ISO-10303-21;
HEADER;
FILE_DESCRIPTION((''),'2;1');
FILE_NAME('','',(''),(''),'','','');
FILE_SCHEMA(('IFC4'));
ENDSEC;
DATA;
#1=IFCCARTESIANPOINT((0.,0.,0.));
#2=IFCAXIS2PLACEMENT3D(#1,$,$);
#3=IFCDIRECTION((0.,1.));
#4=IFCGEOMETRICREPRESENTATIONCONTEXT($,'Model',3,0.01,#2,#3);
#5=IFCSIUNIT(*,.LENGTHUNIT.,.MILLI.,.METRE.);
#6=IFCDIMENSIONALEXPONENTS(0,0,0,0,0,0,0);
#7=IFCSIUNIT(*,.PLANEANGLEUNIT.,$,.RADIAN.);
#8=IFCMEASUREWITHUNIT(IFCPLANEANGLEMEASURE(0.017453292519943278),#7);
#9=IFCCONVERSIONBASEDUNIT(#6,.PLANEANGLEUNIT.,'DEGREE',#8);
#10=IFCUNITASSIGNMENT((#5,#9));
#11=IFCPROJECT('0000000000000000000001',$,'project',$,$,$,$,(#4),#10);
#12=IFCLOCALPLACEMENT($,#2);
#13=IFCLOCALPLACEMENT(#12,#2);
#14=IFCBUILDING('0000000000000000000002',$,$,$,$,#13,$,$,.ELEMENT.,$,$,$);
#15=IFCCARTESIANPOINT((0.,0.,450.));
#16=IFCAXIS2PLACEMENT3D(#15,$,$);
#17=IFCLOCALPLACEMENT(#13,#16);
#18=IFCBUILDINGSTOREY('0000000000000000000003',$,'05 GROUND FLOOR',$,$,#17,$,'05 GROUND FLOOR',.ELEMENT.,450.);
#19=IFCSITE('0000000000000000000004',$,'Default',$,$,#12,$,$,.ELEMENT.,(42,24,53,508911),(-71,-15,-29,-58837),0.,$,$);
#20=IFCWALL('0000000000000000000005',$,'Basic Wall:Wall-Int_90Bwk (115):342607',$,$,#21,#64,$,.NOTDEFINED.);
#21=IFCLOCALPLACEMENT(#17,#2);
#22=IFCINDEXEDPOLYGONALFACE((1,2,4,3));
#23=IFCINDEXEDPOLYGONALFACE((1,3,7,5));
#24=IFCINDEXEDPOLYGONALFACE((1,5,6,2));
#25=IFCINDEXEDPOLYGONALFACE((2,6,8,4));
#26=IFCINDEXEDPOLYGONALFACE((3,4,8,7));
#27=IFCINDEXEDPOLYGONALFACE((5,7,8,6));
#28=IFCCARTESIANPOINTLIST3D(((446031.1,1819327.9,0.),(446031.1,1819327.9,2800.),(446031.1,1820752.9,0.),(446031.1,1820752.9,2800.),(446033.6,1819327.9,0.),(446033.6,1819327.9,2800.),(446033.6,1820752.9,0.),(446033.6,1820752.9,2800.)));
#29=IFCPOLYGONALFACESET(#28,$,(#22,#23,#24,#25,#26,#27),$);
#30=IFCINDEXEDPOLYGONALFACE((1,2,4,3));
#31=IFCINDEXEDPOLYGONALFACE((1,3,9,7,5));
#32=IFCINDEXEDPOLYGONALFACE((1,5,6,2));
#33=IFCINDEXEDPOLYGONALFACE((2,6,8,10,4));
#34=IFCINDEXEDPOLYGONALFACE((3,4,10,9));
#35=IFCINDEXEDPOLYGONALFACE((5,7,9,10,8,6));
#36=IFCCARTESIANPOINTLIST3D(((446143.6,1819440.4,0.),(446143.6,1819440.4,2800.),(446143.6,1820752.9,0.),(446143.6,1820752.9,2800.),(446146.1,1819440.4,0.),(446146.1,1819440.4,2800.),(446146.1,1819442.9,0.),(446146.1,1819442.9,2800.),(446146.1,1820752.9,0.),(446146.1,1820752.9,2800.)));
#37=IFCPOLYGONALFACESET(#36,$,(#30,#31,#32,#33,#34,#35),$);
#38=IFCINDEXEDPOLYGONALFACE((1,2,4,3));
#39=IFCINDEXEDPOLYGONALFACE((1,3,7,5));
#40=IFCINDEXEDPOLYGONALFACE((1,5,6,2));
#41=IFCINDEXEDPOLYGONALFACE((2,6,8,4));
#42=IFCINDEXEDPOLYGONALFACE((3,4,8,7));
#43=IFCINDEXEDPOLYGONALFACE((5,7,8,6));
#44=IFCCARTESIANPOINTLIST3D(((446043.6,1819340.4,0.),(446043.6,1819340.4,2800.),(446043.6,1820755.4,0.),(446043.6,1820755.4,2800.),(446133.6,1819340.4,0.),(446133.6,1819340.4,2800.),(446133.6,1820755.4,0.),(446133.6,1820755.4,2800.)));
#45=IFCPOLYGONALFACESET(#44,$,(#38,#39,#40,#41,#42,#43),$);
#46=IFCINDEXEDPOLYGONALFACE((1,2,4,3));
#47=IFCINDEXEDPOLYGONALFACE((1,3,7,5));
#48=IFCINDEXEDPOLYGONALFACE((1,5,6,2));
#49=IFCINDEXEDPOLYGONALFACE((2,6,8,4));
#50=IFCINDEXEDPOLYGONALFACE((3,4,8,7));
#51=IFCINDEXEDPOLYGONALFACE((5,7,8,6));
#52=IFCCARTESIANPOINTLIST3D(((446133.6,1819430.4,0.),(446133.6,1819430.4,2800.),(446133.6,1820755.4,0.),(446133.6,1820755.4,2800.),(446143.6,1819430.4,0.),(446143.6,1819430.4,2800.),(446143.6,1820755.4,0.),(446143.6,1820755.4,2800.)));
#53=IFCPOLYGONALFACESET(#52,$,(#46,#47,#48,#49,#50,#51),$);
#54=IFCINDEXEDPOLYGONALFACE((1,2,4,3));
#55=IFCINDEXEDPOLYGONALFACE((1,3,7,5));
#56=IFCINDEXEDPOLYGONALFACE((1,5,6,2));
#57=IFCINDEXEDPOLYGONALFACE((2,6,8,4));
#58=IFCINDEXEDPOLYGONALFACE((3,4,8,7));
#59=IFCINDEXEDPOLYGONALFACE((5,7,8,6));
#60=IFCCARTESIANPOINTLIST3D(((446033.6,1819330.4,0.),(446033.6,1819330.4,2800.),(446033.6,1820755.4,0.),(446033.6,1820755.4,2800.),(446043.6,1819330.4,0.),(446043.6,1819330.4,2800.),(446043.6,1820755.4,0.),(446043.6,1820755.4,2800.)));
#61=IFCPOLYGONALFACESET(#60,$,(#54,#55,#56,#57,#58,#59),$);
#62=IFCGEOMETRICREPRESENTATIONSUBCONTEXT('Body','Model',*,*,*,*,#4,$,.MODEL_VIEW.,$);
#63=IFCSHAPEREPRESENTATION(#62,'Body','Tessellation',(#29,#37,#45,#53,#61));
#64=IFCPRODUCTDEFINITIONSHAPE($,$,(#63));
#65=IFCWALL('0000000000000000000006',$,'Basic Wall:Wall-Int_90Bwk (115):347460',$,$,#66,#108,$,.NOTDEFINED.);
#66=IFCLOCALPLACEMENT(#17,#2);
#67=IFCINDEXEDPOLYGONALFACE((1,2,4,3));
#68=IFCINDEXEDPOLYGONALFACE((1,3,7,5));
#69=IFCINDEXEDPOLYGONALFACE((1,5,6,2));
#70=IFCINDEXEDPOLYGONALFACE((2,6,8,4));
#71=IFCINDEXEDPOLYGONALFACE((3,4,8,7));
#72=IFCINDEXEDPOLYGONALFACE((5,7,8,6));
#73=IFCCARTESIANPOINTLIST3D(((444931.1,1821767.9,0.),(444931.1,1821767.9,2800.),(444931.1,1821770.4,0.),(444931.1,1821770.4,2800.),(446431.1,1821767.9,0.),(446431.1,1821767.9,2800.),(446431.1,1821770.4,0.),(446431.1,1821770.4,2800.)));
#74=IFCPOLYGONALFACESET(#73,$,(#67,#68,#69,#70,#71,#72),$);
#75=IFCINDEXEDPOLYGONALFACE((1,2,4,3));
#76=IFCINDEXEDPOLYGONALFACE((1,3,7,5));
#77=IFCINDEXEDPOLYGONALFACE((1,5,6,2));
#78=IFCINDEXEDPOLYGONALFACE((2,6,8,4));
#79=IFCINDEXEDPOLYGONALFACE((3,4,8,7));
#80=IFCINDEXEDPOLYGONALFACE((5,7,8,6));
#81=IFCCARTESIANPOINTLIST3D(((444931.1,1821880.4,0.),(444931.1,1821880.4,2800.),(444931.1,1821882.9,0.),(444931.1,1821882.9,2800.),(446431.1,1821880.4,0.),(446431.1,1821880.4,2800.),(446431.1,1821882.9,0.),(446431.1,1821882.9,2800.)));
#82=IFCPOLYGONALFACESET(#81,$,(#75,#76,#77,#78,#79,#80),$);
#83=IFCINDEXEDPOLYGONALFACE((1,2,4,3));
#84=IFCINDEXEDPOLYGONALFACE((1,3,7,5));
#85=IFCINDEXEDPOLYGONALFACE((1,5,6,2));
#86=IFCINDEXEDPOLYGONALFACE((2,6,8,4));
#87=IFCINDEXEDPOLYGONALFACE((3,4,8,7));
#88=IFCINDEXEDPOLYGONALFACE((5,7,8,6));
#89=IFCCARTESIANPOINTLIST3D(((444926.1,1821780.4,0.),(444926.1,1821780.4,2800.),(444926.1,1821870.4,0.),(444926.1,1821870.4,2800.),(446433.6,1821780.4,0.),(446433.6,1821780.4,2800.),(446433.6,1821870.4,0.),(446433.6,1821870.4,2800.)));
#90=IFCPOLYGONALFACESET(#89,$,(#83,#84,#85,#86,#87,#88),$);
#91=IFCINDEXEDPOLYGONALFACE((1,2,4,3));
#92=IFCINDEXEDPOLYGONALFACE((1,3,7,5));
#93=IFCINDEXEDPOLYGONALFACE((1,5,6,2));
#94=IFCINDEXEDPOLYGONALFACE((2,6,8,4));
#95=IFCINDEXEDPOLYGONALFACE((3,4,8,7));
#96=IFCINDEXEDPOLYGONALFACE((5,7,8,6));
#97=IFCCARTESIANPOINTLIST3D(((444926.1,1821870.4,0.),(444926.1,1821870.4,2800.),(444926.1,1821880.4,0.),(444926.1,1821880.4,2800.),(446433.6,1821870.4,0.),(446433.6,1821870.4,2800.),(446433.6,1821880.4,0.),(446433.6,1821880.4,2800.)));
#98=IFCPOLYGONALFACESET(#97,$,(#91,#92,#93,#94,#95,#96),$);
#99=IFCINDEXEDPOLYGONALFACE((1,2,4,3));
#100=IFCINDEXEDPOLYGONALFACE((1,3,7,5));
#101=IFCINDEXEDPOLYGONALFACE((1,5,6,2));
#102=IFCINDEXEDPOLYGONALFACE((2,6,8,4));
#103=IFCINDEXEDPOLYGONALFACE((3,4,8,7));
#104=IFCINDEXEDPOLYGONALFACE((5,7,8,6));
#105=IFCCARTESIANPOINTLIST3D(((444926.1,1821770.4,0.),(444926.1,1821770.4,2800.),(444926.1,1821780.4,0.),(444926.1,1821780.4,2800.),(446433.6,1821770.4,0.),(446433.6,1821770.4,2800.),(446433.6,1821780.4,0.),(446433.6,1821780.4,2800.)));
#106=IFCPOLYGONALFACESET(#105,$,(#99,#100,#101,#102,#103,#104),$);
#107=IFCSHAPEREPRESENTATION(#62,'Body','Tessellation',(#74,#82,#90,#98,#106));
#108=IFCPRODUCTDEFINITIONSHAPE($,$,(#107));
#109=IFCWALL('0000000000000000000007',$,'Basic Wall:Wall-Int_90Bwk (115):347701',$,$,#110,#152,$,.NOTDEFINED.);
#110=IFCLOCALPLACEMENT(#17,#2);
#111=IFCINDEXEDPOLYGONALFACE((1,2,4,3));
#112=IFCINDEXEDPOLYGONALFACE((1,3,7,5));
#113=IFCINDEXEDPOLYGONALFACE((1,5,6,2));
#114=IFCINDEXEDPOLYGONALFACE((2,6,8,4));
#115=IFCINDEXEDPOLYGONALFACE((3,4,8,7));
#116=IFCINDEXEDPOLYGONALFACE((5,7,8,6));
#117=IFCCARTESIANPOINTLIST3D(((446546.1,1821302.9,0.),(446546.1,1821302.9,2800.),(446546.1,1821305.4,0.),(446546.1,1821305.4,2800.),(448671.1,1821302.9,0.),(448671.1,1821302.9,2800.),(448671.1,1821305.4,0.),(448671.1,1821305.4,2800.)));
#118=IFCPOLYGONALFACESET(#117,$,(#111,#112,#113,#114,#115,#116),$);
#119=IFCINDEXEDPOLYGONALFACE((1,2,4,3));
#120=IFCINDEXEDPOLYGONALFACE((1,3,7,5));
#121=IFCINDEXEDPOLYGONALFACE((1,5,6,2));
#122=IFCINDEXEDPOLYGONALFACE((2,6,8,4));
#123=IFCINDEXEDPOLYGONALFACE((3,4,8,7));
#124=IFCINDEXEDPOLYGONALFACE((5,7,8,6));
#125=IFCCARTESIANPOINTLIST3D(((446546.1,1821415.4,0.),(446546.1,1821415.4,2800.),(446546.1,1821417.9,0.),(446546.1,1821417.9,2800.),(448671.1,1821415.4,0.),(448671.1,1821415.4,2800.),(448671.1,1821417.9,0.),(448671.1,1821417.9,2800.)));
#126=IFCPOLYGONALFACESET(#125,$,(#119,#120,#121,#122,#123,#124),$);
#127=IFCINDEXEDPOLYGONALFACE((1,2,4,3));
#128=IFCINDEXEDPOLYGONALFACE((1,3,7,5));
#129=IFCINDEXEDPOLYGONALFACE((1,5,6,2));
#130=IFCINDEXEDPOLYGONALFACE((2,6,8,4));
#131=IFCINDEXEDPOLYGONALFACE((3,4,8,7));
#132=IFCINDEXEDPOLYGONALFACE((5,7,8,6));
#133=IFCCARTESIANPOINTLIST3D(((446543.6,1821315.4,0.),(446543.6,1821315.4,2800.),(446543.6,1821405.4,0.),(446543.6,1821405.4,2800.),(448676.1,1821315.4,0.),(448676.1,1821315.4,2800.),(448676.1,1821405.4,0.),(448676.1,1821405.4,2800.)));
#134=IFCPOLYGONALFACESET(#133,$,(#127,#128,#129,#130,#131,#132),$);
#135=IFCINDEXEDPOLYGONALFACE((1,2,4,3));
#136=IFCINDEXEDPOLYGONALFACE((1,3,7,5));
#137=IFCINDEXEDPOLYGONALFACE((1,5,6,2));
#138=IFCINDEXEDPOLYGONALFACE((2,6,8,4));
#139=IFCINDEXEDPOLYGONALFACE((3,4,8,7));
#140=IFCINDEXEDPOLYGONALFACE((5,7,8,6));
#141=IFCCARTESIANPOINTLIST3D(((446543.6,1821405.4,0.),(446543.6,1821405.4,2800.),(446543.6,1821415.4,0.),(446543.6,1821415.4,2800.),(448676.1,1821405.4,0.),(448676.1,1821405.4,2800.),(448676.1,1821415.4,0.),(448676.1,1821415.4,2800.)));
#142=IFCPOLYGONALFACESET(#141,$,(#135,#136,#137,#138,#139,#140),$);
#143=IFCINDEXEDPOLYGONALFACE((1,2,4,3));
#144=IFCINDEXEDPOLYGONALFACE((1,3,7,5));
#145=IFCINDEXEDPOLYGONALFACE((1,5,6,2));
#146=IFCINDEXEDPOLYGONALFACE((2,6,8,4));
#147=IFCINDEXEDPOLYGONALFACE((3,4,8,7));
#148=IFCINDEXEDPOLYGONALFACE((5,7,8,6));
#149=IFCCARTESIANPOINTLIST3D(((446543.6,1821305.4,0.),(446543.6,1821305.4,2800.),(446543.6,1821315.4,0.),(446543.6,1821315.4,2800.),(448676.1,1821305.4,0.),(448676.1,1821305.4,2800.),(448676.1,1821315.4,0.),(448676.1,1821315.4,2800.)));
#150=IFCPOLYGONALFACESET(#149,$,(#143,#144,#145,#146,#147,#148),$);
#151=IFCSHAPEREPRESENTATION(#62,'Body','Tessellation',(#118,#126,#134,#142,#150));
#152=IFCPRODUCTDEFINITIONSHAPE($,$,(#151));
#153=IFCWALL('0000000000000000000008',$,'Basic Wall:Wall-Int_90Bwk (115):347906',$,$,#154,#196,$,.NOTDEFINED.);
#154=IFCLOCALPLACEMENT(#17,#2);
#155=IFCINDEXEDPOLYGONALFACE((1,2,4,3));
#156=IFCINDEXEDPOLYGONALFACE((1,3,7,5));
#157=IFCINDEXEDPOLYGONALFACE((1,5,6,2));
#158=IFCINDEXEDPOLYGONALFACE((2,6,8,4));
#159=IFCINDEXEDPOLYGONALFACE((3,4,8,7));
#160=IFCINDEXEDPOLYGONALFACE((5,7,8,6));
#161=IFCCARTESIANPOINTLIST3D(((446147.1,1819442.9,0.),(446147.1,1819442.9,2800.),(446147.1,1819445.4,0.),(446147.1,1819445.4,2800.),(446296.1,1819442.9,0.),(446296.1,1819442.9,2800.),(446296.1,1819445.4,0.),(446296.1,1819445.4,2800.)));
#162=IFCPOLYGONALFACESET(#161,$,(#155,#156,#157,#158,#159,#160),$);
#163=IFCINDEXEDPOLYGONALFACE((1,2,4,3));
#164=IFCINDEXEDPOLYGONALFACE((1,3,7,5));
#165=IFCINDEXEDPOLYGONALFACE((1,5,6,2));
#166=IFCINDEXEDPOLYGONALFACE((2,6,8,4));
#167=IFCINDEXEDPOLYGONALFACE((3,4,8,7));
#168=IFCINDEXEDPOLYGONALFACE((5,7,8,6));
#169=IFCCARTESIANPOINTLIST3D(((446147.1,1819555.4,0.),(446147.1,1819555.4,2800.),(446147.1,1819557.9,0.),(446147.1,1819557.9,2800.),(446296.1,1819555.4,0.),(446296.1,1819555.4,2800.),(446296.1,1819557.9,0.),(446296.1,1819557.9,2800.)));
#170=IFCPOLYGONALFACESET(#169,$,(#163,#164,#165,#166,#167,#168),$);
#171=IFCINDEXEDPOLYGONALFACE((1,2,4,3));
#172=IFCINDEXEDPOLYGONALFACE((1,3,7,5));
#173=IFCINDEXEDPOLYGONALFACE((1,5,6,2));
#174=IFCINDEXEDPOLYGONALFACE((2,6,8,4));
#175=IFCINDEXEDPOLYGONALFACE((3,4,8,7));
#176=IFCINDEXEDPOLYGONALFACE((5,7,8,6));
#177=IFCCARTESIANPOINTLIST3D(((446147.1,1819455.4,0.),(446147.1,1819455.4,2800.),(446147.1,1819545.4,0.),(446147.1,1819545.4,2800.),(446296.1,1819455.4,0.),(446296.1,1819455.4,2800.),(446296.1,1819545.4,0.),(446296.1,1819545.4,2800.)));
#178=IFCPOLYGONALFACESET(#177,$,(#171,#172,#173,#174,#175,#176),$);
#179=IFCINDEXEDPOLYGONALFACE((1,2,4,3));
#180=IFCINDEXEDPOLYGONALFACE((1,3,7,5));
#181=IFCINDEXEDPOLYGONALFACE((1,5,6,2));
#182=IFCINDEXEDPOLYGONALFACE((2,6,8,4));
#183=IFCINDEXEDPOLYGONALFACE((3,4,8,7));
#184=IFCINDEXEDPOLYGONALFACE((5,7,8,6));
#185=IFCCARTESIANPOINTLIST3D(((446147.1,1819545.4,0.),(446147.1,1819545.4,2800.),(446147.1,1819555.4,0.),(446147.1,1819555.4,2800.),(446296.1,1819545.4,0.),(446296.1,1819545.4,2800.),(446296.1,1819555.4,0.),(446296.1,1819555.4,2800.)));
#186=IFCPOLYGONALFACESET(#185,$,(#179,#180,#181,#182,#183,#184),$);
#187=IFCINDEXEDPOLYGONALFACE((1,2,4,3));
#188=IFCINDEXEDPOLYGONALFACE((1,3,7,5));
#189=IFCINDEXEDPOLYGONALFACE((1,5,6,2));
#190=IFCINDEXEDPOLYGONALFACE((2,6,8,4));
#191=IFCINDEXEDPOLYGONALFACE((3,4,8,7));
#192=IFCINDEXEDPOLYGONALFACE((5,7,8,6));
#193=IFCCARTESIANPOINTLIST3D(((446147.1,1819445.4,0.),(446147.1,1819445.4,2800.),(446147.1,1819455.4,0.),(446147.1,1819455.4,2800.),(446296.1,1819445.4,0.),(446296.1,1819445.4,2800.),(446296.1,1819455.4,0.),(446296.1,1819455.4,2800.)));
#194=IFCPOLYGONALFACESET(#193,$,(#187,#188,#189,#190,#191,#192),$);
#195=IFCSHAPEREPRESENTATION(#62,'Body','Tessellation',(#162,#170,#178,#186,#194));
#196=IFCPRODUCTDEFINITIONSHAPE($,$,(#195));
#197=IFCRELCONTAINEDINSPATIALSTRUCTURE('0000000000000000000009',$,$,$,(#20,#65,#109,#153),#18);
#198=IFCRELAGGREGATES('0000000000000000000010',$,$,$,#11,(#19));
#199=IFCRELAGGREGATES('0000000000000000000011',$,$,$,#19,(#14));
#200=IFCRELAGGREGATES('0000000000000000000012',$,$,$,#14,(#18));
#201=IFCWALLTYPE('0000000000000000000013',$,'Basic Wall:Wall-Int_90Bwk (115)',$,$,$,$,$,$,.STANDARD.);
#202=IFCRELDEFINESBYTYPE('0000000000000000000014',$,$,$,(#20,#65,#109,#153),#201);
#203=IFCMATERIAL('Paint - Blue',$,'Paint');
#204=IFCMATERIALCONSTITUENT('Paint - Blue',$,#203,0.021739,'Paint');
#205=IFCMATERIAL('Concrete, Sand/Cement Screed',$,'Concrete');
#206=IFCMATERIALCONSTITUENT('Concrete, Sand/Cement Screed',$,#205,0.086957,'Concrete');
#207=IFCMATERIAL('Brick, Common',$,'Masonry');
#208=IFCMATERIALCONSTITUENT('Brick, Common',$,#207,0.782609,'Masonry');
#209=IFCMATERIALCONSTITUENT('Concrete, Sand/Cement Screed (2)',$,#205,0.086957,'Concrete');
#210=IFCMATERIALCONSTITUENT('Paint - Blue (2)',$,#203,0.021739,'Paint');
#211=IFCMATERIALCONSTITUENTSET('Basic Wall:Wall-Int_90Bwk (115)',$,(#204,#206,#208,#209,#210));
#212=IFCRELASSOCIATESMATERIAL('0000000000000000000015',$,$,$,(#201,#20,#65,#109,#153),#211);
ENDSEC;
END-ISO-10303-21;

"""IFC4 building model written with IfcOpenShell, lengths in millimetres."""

from ifc_helpers import new_model, entity, si_unit, converted_unit, direction, frame, origin, place, context, subcontext, project, spatial, indexed_curve, outline, extrude, material, constituent, constituent_set, type_object, element, save


model = new_model("IFC4")

# Units and contexts
model_context = context("Model", 3, precision=0.01, world=origin(), true_north=direction((0.0, 1.0)))
body_context = subcontext(model_context, "Body", "Model", "MODEL_VIEW")
ifc_project = project(units=[si_unit("LENGTHUNIT", "METRE", prefix="MILLI"), converted_unit("PLANEANGLEUNIT", "DEGREE", entity("IfcPlaneAngleMeasure", 0.017453292519943278), si_unit("PLANEANGLEUNIT", "RADIAN"), dimensions=[0, 0, 0, 0, 0, 0, 0])], contexts=[model_context])

# Site, building, storey
site_placement = place(None, origin())
site = spatial("IfcSite", under=ifc_project, at=site_placement, Name="Default", CompositionType="ELEMENT", RefLatitude=(42, 24, 53, 508911), RefLongitude=(-71, -15, -29, -58837), RefElevation=0.0)
building_placement = place(site_placement, origin())
building = spatial("IfcBuilding", under=site, at=building_placement, CompositionType="ELEMENT")
storey_placement = place(building_placement, frame((0.0, 0.0, 450.0)))
storey = spatial("IfcBuildingStorey", under=building, at=storey_placement, Name="05 GROUND FLOOR", LongName="05 GROUND FLOOR", CompositionType="ELEMENT", Elevation=450.0)

# Shared definitions
ifc_material_1 = material(Name="Paint - Blue", Category="Paint")
ifc_constituent_1 = constituent(ifc_material_1, Name="Paint - Blue", Category="Paint", fraction=0.021739)
ifc_material_2 = material(Name="Concrete, Sand/Cement Screed", Category="Concrete")
ifc_constituent_2 = constituent(ifc_material_2, Name="Concrete, Sand/Cement Screed", Category="Concrete", fraction=0.086957)
ifc_material_3 = material(Name="Brick, Common", Category="Masonry")
ifc_constituent_3 = constituent(ifc_material_3, Name="Brick, Common", Category="Masonry", fraction=0.782609)
ifc_constituent_4 = constituent(ifc_material_2, Name="Concrete, Sand/Cement Screed (2)", Category="Concrete", fraction=0.086957)
ifc_constituent_5 = constituent(ifc_material_1, Name="Paint - Blue (2)", Category="Paint", fraction=0.021739)
ifc_constituent_set_1 = constituent_set(constituents=[ifc_constituent_1, ifc_constituent_2, ifc_constituent_3, ifc_constituent_4, ifc_constituent_5], Name="Basic Wall:Wall-Int_90Bwk (115)")
wall_type_1 = type_object("IfcWallType", Name="Basic Wall:Wall-Int_90Bwk (115)", PredefinedType="STANDARD", material=ifc_constituent_set_1)

# Wall
wall_1_placement = place(storey_placement, frame((446088.6, 1820752.9, 0.0), z_axis=(0.0, 0.0, 1.0), x_axis=(0.0, -1.0, 0.0)))
element("IfcWall", 1, at=wall_1_placement, inside=storey, type_object=wall_type_1, material=ifc_constituent_set_1, Name="Basic Wall:Wall-Int_90Bwk (115):342607", PredefinedType="NOTDEFINED", context=body_context, shape_type="SweptSolid", body=[
    extrude(outline(indexed_curve([(-1.3, -712.5), (1.2, -712.5), (1.2, 712.5), (-1.3, 712.5), (-1.3, -712.5)], self_intersect=False)), frame((712.5, -56.2, 0.0), z_axis=(0.0, 0.0, 1.0), x_axis=(0.0, 1.0, 0.0)), (0.0, 0.0, 1.0), 2800.0),
    extrude(outline(indexed_curve([(-523.0, -1.0), (787.0, -1.0), (787.0, 1.5), (-525.5, 1.5), (-525.5, -1.0), (-523.0, -1.0)], self_intersect=False)), frame((787.0, 56.5, 0.0), z_axis=(0.0, 0.0, 1.0), x_axis=(-1.0, 0.0, 0.0)), (0.0, 0.0, 1.0), 2800.0),
    extrude(outline(indexed_curve([(-707.5, -45.0), (707.5, -45.0), (707.5, 45.0), (-707.5, 45.0), (-707.5, -45.0)], self_intersect=False)), frame((705.0, 0.0, 0.0)), (0.0, 0.0, 1.0), 2800.0),
    extrude(outline(indexed_curve([(-662.5, -5.0), (662.5, -5.0), (662.5, 5.0), (-662.5, 5.0), (-662.5, -5.0)], self_intersect=False)), frame((660.0, 50.0, 0.0)), (0.0, 0.0, 1.0), 2800.0),
    extrude(outline(indexed_curve([(-712.5, -5.0), (712.5, -5.0), (712.5, 5.0), (-712.5, 5.0), (-712.5, -5.0)], self_intersect=False)), frame((710.0, -50.0, 0.0)), (0.0, 0.0, 1.0), 2800.0),
])

# Walls
wall_2_placement = place(storey_placement, frame((444931.1, 1821825.4, 0.0)))
element("IfcWall", 2, at=wall_2_placement, inside=storey, type_object=wall_type_1, material=ifc_constituent_set_1, Name="Basic Wall:Wall-Int_90Bwk (115):347460", PredefinedType="NOTDEFINED", context=body_context, shape_type="SweptSolid", body=[
    extrude(outline(indexed_curve([(-1.3, -750.0), (1.2, -750.0), (1.2, 750.0), (-1.3, 750.0), (-1.3, -750.0)], self_intersect=False)), frame((750.0, -56.2, 0.0), z_axis=(0.0, 0.0, 1.0), x_axis=(0.0, 1.0, 0.0)), (0.0, 0.0, 1.0), 2800.0),
    extrude(outline(indexed_curve([(-1.3, -750.0), (1.3, -750.0), (1.3, 750.0), (-1.3, 750.0), (-1.3, -750.0)], self_intersect=False)), frame((750.0, 56.3, 0.0), z_axis=(0.0, 0.0, 1.0), x_axis=(0.0, -1.0, 0.0)), (0.0, 0.0, 1.0), 2800.0),
    extrude(outline(indexed_curve([(-753.8, -45.0), (753.8, -45.0), (753.8, 45.0), (-753.8, 45.0), (-753.8, -45.0)], self_intersect=False)), frame((748.8, 0.0, 0.0)), (0.0, 0.0, 1.0), 2800.0),
    extrude(outline(indexed_curve([(-753.8, -5.0), (753.8, -5.0), (753.8, 5.0), (-753.8, 5.0), (-753.8, -5.0)], self_intersect=False)), frame((748.8, 50.0, 0.0)), (0.0, 0.0, 1.0), 2800.0),
    extrude(outline(indexed_curve([(-753.8, -5.0), (753.8, -5.0), (753.8, 5.0), (-753.8, 5.0), (-753.8, -5.0)], self_intersect=False)), frame((748.8, -50.0, 0.0)), (0.0, 0.0, 1.0), 2800.0),
])
wall_3_placement = place(storey_placement, frame((446546.1, 1821360.4, 0.0)))
element("IfcWall", 3, at=wall_3_placement, inside=storey, type_object=wall_type_1, material=ifc_constituent_set_1, Name="Basic Wall:Wall-Int_90Bwk (115):347701", PredefinedType="NOTDEFINED", context=body_context, shape_type="SweptSolid", body=[
    extrude(outline(indexed_curve([(-1.2, -1062.5), (1.3, -1062.5), (1.3, 1062.5), (-1.2, 1062.5), (-1.2, -1062.5)], self_intersect=False)), frame((1062.5, -56.3, 0.0), z_axis=(0.0, 0.0, 1.0), x_axis=(0.0, 1.0, 0.0)), (0.0, 0.0, 1.0), 2800.0),
    extrude(outline(indexed_curve([(-1.2, -1062.5), (1.3, -1062.5), (1.3, 1062.5), (-1.2, 1062.5), (-1.2, -1062.5)], self_intersect=False)), frame((1062.5, 56.3, 0.0), z_axis=(0.0, 0.0, 1.0), x_axis=(0.0, -1.0, 0.0)), (0.0, 0.0, 1.0), 2800.0),
    extrude(outline(indexed_curve([(-1066.2, -45.0), (1066.2, -45.0), (1066.2, 45.0), (-1066.2, 45.0), (-1066.2, -45.0)], self_intersect=False)), frame((1063.7, 0.0, 0.0)), (0.0, 0.0, 1.0), 2800.0),
    extrude(outline(indexed_curve([(-1066.2, -5.0), (1066.2, -5.0), (1066.2, 5.0), (-1066.2, 5.0), (-1066.2, -5.0)], self_intersect=False)), frame((1063.7, 50.0, 0.0)), (0.0, 0.0, 1.0), 2800.0),
    extrude(outline(indexed_curve([(-1066.2, -5.0), (1066.2, -5.0), (1066.2, 5.0), (-1066.2, 5.0), (-1066.2, -5.0)], self_intersect=False)), frame((1063.7, -50.0, 0.0)), (0.0, 0.0, 1.0), 2800.0),
])
wall_4_placement = place(storey_placement, frame((446147.1, 1819500.4, 0.0)))
element("IfcWall", 4, at=wall_4_placement, inside=storey, type_object=wall_type_1, material=ifc_constituent_set_1, Name="Basic Wall:Wall-Int_90Bwk (115):347906", PredefinedType="NOTDEFINED", context=body_context, shape_type="SweptSolid", body=[
    extrude(outline(indexed_curve([(-1.3, -74.5), (1.2, -74.5), (1.2, 74.5), (-1.3, 74.5), (-1.3, -74.5)], self_intersect=False)), frame((74.5, -56.2, 0.0), z_axis=(0.0, 0.0, 1.0), x_axis=(0.0, 1.0, 0.0)), (0.0, 0.0, 1.0), 2800.0),
    extrude(outline(indexed_curve([(-1.3, -74.5), (1.2, -74.5), (1.2, 74.5), (-1.3, 74.5), (-1.3, -74.5)], self_intersect=False)), frame((74.5, 56.2, 0.0), z_axis=(0.0, 0.0, 1.0), x_axis=(0.0, -1.0, 0.0)), (0.0, 0.0, 1.0), 2800.0),
    extrude(outline(indexed_curve([(-74.5, -45.0), (74.5, -45.0), (74.5, 45.0), (-74.5, 45.0), (-74.5, -45.0)], self_intersect=False)), frame((74.5, 0.0, 0.0)), (0.0, 0.0, 1.0), 2800.0),
    extrude(outline(indexed_curve([(-74.5, -5.0), (74.5, -5.0), (74.5, 5.0), (-74.5, 5.0), (-74.5, -5.0)], self_intersect=False)), frame((74.5, 50.0, 0.0)), (0.0, 0.0, 1.0), 2800.0),
    extrude(outline(indexed_curve([(-74.5, -5.0), (74.5, -5.0), (74.5, 5.0), (-74.5, 5.0), (-74.5, -5.0)], self_intersect=False)), frame((74.5, -50.0, 0.0)), (0.0, 0.0, 1.0), 2800.0),
])

save(model, "model.ifc")
